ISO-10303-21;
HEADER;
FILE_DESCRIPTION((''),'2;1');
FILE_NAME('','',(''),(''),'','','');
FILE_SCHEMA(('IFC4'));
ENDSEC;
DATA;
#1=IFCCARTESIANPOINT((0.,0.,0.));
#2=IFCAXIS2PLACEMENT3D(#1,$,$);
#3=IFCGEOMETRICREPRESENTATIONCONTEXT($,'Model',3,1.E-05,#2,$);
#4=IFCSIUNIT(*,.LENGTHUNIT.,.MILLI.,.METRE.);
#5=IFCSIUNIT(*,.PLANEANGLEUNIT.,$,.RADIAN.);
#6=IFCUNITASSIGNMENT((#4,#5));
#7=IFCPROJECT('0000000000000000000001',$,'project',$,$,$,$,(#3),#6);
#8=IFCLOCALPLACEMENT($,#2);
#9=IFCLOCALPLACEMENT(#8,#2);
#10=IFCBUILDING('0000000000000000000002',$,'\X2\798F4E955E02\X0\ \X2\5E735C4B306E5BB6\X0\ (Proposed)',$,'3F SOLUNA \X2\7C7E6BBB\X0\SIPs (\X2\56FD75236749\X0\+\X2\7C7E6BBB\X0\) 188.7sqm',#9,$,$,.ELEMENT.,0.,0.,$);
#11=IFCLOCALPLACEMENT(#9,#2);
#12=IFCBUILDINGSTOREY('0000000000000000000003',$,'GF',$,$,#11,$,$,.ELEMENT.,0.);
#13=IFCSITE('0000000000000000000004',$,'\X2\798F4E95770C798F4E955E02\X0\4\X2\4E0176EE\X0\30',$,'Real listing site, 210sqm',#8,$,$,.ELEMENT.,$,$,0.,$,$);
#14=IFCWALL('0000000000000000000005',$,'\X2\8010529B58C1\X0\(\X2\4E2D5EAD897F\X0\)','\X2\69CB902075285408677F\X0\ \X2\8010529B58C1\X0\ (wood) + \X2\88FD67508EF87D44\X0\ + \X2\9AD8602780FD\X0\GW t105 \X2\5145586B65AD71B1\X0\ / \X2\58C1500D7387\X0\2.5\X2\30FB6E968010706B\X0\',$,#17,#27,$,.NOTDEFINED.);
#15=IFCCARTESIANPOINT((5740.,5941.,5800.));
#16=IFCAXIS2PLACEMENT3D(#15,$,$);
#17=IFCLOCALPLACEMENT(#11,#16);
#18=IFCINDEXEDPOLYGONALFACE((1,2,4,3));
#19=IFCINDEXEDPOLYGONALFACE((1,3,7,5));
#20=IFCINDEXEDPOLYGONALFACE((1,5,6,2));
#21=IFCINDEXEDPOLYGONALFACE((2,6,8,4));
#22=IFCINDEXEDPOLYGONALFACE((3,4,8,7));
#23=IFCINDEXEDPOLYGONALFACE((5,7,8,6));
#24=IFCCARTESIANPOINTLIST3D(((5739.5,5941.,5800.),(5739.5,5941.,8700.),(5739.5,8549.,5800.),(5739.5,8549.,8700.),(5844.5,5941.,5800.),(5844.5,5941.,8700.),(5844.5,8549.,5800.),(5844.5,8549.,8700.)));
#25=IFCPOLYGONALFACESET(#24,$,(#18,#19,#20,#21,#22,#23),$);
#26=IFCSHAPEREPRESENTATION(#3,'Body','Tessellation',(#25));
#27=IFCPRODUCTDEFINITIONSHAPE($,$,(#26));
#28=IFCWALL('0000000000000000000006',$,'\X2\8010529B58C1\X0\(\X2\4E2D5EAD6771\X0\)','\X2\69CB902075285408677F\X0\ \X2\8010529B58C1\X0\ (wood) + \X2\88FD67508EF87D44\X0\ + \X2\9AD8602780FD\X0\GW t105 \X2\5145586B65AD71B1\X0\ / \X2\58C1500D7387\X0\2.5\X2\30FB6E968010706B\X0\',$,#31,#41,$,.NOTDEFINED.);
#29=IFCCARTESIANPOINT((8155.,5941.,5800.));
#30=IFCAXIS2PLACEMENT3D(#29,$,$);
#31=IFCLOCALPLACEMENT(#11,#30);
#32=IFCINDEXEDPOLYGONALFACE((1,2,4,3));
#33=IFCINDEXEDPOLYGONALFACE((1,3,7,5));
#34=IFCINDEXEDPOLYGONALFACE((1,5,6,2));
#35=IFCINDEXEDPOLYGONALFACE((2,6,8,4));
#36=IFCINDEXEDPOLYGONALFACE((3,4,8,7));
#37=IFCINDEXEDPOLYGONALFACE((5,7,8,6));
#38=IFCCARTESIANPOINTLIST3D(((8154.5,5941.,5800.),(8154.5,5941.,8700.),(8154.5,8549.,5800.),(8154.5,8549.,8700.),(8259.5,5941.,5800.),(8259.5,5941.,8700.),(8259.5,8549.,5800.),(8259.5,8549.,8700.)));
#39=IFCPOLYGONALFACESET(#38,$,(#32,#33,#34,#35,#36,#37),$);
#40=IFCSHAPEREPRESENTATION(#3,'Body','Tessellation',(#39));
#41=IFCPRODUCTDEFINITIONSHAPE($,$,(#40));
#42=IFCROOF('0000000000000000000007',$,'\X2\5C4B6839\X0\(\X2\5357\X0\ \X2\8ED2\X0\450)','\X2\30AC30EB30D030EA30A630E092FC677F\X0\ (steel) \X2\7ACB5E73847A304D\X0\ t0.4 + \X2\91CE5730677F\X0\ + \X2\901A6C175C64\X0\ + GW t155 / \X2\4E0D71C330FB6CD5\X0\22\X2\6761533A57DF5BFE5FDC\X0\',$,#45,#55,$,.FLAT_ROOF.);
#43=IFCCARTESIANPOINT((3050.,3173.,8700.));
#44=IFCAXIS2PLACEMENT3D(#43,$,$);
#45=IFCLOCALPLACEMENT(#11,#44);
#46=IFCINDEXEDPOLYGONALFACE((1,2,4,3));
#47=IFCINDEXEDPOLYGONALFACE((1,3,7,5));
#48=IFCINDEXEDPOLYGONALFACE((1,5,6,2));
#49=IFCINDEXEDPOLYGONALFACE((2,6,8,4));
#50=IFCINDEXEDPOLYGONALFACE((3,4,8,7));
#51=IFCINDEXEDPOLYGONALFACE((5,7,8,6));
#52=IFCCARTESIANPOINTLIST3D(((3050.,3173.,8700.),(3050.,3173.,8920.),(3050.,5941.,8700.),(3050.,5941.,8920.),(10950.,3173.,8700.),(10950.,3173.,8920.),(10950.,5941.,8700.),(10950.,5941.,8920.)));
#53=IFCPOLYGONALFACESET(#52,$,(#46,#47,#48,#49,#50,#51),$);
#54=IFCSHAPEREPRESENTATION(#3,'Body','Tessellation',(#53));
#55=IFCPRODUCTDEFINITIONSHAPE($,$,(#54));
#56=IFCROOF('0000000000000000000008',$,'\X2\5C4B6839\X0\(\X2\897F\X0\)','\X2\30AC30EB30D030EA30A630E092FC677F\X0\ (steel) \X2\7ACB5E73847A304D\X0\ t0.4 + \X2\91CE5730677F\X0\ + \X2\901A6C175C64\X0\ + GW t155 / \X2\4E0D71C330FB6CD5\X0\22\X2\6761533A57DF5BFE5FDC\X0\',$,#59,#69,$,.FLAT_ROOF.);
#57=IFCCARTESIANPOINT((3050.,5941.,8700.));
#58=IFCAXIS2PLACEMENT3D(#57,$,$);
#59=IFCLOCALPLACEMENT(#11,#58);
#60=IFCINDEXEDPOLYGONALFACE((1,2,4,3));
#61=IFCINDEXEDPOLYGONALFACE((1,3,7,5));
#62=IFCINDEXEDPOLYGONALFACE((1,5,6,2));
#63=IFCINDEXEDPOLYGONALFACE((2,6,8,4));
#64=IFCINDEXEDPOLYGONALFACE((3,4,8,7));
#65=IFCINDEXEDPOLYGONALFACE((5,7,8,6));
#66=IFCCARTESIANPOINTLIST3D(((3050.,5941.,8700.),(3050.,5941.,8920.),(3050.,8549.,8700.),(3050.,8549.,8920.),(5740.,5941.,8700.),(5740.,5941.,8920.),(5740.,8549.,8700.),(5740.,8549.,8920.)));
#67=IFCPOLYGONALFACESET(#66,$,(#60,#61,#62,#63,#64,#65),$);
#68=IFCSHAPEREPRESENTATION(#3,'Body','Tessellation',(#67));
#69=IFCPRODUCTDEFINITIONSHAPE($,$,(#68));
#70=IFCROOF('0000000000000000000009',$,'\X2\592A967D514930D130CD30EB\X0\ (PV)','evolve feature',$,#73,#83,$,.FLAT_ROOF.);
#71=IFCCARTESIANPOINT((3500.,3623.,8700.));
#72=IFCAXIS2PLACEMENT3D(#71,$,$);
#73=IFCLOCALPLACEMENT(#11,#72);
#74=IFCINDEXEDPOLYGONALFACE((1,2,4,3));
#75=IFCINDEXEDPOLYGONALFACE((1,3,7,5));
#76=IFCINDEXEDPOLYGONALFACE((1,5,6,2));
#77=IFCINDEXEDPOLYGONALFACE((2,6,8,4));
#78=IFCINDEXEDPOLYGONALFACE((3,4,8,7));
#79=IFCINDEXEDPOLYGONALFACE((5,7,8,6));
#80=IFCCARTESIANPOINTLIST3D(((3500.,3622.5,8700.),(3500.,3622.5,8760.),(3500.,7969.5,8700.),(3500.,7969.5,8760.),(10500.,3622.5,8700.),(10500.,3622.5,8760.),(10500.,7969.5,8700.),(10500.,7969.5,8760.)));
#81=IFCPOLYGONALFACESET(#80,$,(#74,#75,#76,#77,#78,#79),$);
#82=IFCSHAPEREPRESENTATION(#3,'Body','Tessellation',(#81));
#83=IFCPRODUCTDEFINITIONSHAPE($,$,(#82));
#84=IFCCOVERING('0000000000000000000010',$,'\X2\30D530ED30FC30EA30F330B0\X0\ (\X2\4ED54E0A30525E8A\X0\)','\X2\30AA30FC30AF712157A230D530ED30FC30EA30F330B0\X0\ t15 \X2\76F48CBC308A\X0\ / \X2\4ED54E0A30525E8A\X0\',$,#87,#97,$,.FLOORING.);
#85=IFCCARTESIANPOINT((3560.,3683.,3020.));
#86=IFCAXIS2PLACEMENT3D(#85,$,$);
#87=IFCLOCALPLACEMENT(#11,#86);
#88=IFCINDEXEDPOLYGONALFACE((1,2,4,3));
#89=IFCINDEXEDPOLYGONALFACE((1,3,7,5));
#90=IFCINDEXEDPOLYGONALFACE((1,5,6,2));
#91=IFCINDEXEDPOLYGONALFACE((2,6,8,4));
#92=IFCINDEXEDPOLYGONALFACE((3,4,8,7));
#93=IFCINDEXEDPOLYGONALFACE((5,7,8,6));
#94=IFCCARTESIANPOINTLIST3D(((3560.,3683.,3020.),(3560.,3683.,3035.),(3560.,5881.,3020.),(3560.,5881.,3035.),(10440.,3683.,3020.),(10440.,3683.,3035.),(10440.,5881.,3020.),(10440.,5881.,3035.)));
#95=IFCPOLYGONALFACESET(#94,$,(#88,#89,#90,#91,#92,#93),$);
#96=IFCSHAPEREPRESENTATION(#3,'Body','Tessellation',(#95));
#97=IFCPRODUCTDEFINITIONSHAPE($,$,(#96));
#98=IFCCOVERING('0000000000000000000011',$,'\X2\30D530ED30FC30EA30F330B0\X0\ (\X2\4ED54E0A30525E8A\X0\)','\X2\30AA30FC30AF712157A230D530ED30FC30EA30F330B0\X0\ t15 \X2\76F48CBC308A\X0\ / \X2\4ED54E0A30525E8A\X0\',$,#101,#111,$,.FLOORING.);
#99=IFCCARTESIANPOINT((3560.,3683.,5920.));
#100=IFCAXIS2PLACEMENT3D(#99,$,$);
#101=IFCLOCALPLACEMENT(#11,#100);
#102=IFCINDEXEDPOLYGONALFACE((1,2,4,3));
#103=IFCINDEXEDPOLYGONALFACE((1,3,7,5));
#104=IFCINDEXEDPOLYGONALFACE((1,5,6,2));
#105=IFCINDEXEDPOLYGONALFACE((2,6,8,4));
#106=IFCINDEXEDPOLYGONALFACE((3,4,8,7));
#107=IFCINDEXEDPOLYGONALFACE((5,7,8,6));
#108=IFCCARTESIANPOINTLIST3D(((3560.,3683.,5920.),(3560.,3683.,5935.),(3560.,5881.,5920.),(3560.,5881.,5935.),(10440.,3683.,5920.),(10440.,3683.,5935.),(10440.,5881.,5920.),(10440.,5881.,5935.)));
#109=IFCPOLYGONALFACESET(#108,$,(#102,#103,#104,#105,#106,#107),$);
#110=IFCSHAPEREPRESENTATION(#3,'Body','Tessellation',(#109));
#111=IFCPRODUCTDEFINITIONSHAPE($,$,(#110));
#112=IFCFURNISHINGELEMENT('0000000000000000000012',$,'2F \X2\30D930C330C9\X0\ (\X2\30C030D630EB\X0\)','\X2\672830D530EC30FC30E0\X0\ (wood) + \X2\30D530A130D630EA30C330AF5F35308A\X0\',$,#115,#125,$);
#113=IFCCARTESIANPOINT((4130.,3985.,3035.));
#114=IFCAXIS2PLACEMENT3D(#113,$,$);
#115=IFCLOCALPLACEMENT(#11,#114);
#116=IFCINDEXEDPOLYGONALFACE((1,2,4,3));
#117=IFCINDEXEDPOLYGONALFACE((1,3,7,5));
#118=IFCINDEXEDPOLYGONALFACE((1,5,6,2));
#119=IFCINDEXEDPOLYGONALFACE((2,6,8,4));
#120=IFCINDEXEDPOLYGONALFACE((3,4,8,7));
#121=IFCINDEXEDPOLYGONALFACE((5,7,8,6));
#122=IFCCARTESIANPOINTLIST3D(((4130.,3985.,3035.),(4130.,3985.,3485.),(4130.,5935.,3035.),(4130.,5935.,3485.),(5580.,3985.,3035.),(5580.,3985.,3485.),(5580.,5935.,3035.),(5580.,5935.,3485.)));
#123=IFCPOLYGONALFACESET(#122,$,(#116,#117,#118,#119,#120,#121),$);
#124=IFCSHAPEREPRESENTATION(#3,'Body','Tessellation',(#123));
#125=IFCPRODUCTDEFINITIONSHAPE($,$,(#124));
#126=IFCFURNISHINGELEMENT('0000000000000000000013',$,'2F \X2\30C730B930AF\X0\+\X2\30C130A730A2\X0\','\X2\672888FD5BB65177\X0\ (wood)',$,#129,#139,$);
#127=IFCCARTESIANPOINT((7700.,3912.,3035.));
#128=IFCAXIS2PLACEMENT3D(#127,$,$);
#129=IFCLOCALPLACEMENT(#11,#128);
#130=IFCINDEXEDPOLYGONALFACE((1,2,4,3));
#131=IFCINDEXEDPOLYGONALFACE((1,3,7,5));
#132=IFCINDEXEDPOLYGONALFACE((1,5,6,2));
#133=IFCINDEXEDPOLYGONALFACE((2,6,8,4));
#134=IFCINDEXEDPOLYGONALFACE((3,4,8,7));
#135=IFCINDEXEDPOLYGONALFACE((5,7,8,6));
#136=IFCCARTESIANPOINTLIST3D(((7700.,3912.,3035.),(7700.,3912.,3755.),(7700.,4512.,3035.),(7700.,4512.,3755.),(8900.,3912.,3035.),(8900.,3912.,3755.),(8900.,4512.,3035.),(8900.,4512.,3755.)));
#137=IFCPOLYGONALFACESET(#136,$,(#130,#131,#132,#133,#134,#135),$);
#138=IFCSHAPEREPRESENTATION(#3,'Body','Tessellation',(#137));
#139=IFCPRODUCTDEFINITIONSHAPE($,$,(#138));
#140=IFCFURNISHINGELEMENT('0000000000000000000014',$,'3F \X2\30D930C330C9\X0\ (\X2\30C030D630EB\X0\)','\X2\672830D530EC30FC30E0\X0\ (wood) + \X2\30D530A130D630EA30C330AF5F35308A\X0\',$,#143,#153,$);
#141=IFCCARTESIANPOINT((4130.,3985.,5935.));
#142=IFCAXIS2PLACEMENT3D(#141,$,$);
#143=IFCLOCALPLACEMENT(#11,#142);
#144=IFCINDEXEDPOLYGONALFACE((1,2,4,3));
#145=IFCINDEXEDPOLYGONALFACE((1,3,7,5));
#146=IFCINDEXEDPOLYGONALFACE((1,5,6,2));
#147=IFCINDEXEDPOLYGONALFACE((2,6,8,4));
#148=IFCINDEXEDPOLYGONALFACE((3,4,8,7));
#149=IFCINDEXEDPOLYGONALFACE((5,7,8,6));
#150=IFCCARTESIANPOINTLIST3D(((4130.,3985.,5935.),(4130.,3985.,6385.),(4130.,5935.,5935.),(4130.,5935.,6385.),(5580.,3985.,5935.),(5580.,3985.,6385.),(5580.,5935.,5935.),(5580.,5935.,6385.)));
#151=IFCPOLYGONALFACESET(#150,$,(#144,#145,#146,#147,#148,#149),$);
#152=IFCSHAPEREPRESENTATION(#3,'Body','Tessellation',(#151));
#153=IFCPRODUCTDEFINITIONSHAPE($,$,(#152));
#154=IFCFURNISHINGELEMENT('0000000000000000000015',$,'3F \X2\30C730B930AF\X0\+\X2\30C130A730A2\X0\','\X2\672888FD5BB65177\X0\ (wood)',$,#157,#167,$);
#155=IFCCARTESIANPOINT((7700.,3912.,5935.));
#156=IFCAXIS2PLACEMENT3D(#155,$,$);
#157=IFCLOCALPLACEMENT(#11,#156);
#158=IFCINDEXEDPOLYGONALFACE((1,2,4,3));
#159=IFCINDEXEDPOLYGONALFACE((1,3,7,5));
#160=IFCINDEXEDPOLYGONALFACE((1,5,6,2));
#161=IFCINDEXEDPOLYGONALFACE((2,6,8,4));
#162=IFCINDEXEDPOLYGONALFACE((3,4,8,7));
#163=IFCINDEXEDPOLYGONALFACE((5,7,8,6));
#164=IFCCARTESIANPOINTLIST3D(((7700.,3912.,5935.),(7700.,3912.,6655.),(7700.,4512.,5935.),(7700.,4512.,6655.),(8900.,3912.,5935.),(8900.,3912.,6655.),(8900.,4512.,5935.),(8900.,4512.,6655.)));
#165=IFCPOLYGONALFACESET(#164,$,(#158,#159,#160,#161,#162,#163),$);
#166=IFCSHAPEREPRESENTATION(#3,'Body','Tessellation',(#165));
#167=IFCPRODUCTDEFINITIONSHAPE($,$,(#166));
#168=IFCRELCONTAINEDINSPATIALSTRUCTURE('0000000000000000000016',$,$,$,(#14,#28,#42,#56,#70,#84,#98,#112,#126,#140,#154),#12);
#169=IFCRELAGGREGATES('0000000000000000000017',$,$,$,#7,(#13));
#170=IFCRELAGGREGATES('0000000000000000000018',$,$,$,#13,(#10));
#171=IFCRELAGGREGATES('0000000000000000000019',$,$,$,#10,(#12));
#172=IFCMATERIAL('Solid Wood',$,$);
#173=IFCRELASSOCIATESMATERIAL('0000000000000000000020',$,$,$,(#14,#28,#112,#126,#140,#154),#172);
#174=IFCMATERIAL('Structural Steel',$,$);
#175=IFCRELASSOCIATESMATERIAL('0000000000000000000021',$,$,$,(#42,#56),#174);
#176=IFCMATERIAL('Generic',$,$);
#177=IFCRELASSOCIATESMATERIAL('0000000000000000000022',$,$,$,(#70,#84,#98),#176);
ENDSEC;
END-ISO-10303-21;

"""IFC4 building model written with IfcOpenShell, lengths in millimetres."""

from ifc_helpers import new_model, si_unit, frame, frame_2d, origin, place, context, project, spatial, rectangle, extrude, material, element, save


model = new_model("IFC4")

# Units and contexts
model_context = context("Model", 3, precision=1e-05, world=origin())
ifc_project = project(units=[si_unit("LENGTHUNIT", "METRE", prefix="MILLI"), si_unit("PLANEANGLEUNIT", "RADIAN")], contexts=[model_context])

# Site, building, storey
site_placement = place(None, origin())
site = spatial("IfcSite", under=ifc_project, at=site_placement, Name="福井県福井市4丁目30", ObjectType="Real listing site, 210sqm", CompositionType="ELEMENT", RefElevation=0.0)
building_placement = place(site_placement, origin())
building = spatial("IfcBuilding", under=site, at=building_placement, Name="福井市 平屋の家 (Proposed)", ObjectType="3F SOLUNA 籾殻SIPs (国産杉+籾殻) 188.7sqm", CompositionType="ELEMENT", ElevationOfRefHeight=0.0, ElevationOfTerrain=0.0)
storey_placement = place(building_placement, origin())
storey = spatial("IfcBuildingStorey", under=building, at=storey_placement, Name="GF", CompositionType="ELEMENT", Elevation=0.0)

# Shared definitions
ifc_material_1 = material(Name="Solid Wood")

# Walls
wall_1_placement = place(storey_placement, frame((5740.0, 5941.0, 5800.0)))
element("IfcWall", 1, at=wall_1_placement, inside=storey, material=ifc_material_1, Name="耐力壁(中庭西)", Description="構造用合板 耐力壁 (wood) + 製材軸組 + 高性能GW t105 充填断熱 / 壁倍率2.5・準耐火", PredefinedType="NOTDEFINED", context=model_context, shape_type="SweptSolid", body=[
    extrude(rectangle(XDim=105.0, YDim=2608.0, at=frame_2d((52.0, 1304.0))), frame((5740.0, 5941.0, 5800.0)), (0.0, 0.0, 1.0), 2900.0),
])
wall_2_placement = place(storey_placement, frame((8155.0, 5941.0, 5800.0)))
element("IfcWall", 2, at=wall_2_placement, inside=storey, material=ifc_material_1, Name="耐力壁(中庭東)", Description="構造用合板 耐力壁 (wood) + 製材軸組 + 高性能GW t105 充填断熱 / 壁倍率2.5・準耐火", PredefinedType="NOTDEFINED", context=model_context, shape_type="SweptSolid", body=[
    extrude(rectangle(XDim=105.0, YDim=2608.0, at=frame_2d((52.0, 1304.0))), frame((8155.0, 5941.0, 5800.0)), (0.0, 0.0, 1.0), 2900.0),
])

# Roofs
ifc_material_2 = material(Name="Structural Steel")
roof_1_placement = place(storey_placement, frame((3050.0, 3173.0, 8700.0)))
element("IfcRoof", 3, at=roof_1_placement, inside=storey, material=ifc_material_2, Name="屋根(南 軒450)", Description="ガルバリウム鋼板 (steel) 立平葺き t0.4 + 野地板 + 通気層 + GW t155 / 不燃・法22条区域対応", PredefinedType="FLAT_ROOF", context=model_context, shape_type="SweptSolid", body=[
    extrude(rectangle(XDim=7900.0, YDim=2768.0, at=frame_2d((3950.0, 1384.0))), frame((3050.0, 3173.0, 8700.0)), (0.0, 0.0, 1.0), 220.0),
])
roof_2_placement = place(storey_placement, frame((3050.0, 5941.0, 8700.0)))
element("IfcRoof", 4, at=roof_2_placement, inside=storey, material=ifc_material_2, Name="屋根(西)", Description="ガルバリウム鋼板 (steel) 立平葺き t0.4 + 野地板 + 通気層 + GW t155 / 不燃・法22条区域対応", PredefinedType="FLAT_ROOF", context=model_context, shape_type="SweptSolid", body=[
    extrude(rectangle(XDim=2690.0, YDim=2608.0, at=frame_2d((1345.0, 1304.0))), frame((3050.0, 5941.0, 8700.0)), (0.0, 0.0, 1.0), 220.0),
])
ifc_material_3 = material(Name="Generic")
roof_3_placement = place(storey_placement, frame((3500.0, 3623.0, 8700.0)))
element("IfcRoof", 5, at=roof_3_placement, inside=storey, material=ifc_material_3, Name="太陽光パネル (PV)", Description="evolve feature", PredefinedType="FLAT_ROOF", context=model_context, shape_type="SweptSolid", body=[
    extrude(rectangle(XDim=7000.0, YDim=4347.0, at=frame_2d((3500.0, 2173.0))), frame((3500.0, 3623.0, 8700.0)), (0.0, 0.0, 1.0), 60.0),
])

# Coverings
covering_1_placement = place(storey_placement, frame((3560.0, 3683.0, 3020.0)))
element("IfcCovering", 6, at=covering_1_placement, inside=storey, material=ifc_material_3, Name="フローリング (仕上げ床)", Description="オーク無垢フローリング t15 直貼り / 仕上げ床", PredefinedType="FLOORING", context=model_context, shape_type="SweptSolid", body=[
    extrude(rectangle(XDim=6880.0, YDim=2198.0, at=frame_2d((3440.0, 1099.0))), frame((3560.0, 3683.0, 3020.0)), (0.0, 0.0, 1.0), 15.0),
])
covering_2_placement = place(storey_placement, frame((3560.0, 3683.0, 5920.0)))
element("IfcCovering", 7, at=covering_2_placement, inside=storey, material=ifc_material_3, Name="フローリング (仕上げ床)", Description="オーク無垢フローリング t15 直貼り / 仕上げ床", PredefinedType="FLOORING", context=model_context, shape_type="SweptSolid", body=[
    extrude(rectangle(XDim=6880.0, YDim=2198.0, at=frame_2d((3440.0, 1099.0))), frame((3560.0, 3683.0, 5920.0)), (0.0, 0.0, 1.0), 15.0),
])

# Furnishing elements
furnishing_1_placement = place(storey_placement, frame((4130.0, 3985.0, 3035.0)))
element("IfcFurnishingElement", 8, at=furnishing_1_placement, inside=storey, material=ifc_material_1, Name="2F ベッド (ダブル)", Description="木フレーム (wood) + ファブリック張り", context=model_context, shape_type="SweptSolid", body=[
    extrude(rectangle(XDim=1450.0, YDim=1950.0, at=frame_2d((725.0, 975.0))), frame((4130.0, 3985.0, 3035.0)), (0.0, 0.0, 1.0), 450.0),
])
furnishing_2_placement = place(storey_placement, frame((7700.0, 3912.0, 3035.0)))
element("IfcFurnishingElement", 9, at=furnishing_2_placement, inside=storey, material=ifc_material_1, Name="2F デスク+チェア", Description="木製家具 (wood)", context=model_context, shape_type="SweptSolid", body=[
    extrude(rectangle(XDim=1200.0, YDim=600.0, at=frame_2d((600.0, 300.0))), frame((7700.0, 3912.0, 3035.0)), (0.0, 0.0, 1.0), 720.0),
])
furnishing_3_placement = place(storey_placement, frame((4130.0, 3985.0, 5935.0)))
element("IfcFurnishingElement", 10, at=furnishing_3_placement, inside=storey, material=ifc_material_1, Name="3F ベッド (ダブル)", Description="木フレーム (wood) + ファブリック張り", context=model_context, shape_type="SweptSolid", body=[
    extrude(rectangle(XDim=1450.0, YDim=1950.0, at=frame_2d((725.0, 975.0))), frame((4130.0, 3985.0, 5935.0)), (0.0, 0.0, 1.0), 450.0),
])
furnishing_4_placement = place(storey_placement, frame((7700.0, 3912.0, 5935.0)))
element("IfcFurnishingElement", 11, at=furnishing_4_placement, inside=storey, material=ifc_material_1, Name="3F デスク+チェア", Description="木製家具 (wood)", context=model_context, shape_type="SweptSolid", body=[
    extrude(rectangle(XDim=1200.0, YDim=600.0, at=frame_2d((600.0, 300.0))), frame((7700.0, 3912.0, 5935.0)), (0.0, 0.0, 1.0), 720.0),
])

save(model, "model.ifc")
